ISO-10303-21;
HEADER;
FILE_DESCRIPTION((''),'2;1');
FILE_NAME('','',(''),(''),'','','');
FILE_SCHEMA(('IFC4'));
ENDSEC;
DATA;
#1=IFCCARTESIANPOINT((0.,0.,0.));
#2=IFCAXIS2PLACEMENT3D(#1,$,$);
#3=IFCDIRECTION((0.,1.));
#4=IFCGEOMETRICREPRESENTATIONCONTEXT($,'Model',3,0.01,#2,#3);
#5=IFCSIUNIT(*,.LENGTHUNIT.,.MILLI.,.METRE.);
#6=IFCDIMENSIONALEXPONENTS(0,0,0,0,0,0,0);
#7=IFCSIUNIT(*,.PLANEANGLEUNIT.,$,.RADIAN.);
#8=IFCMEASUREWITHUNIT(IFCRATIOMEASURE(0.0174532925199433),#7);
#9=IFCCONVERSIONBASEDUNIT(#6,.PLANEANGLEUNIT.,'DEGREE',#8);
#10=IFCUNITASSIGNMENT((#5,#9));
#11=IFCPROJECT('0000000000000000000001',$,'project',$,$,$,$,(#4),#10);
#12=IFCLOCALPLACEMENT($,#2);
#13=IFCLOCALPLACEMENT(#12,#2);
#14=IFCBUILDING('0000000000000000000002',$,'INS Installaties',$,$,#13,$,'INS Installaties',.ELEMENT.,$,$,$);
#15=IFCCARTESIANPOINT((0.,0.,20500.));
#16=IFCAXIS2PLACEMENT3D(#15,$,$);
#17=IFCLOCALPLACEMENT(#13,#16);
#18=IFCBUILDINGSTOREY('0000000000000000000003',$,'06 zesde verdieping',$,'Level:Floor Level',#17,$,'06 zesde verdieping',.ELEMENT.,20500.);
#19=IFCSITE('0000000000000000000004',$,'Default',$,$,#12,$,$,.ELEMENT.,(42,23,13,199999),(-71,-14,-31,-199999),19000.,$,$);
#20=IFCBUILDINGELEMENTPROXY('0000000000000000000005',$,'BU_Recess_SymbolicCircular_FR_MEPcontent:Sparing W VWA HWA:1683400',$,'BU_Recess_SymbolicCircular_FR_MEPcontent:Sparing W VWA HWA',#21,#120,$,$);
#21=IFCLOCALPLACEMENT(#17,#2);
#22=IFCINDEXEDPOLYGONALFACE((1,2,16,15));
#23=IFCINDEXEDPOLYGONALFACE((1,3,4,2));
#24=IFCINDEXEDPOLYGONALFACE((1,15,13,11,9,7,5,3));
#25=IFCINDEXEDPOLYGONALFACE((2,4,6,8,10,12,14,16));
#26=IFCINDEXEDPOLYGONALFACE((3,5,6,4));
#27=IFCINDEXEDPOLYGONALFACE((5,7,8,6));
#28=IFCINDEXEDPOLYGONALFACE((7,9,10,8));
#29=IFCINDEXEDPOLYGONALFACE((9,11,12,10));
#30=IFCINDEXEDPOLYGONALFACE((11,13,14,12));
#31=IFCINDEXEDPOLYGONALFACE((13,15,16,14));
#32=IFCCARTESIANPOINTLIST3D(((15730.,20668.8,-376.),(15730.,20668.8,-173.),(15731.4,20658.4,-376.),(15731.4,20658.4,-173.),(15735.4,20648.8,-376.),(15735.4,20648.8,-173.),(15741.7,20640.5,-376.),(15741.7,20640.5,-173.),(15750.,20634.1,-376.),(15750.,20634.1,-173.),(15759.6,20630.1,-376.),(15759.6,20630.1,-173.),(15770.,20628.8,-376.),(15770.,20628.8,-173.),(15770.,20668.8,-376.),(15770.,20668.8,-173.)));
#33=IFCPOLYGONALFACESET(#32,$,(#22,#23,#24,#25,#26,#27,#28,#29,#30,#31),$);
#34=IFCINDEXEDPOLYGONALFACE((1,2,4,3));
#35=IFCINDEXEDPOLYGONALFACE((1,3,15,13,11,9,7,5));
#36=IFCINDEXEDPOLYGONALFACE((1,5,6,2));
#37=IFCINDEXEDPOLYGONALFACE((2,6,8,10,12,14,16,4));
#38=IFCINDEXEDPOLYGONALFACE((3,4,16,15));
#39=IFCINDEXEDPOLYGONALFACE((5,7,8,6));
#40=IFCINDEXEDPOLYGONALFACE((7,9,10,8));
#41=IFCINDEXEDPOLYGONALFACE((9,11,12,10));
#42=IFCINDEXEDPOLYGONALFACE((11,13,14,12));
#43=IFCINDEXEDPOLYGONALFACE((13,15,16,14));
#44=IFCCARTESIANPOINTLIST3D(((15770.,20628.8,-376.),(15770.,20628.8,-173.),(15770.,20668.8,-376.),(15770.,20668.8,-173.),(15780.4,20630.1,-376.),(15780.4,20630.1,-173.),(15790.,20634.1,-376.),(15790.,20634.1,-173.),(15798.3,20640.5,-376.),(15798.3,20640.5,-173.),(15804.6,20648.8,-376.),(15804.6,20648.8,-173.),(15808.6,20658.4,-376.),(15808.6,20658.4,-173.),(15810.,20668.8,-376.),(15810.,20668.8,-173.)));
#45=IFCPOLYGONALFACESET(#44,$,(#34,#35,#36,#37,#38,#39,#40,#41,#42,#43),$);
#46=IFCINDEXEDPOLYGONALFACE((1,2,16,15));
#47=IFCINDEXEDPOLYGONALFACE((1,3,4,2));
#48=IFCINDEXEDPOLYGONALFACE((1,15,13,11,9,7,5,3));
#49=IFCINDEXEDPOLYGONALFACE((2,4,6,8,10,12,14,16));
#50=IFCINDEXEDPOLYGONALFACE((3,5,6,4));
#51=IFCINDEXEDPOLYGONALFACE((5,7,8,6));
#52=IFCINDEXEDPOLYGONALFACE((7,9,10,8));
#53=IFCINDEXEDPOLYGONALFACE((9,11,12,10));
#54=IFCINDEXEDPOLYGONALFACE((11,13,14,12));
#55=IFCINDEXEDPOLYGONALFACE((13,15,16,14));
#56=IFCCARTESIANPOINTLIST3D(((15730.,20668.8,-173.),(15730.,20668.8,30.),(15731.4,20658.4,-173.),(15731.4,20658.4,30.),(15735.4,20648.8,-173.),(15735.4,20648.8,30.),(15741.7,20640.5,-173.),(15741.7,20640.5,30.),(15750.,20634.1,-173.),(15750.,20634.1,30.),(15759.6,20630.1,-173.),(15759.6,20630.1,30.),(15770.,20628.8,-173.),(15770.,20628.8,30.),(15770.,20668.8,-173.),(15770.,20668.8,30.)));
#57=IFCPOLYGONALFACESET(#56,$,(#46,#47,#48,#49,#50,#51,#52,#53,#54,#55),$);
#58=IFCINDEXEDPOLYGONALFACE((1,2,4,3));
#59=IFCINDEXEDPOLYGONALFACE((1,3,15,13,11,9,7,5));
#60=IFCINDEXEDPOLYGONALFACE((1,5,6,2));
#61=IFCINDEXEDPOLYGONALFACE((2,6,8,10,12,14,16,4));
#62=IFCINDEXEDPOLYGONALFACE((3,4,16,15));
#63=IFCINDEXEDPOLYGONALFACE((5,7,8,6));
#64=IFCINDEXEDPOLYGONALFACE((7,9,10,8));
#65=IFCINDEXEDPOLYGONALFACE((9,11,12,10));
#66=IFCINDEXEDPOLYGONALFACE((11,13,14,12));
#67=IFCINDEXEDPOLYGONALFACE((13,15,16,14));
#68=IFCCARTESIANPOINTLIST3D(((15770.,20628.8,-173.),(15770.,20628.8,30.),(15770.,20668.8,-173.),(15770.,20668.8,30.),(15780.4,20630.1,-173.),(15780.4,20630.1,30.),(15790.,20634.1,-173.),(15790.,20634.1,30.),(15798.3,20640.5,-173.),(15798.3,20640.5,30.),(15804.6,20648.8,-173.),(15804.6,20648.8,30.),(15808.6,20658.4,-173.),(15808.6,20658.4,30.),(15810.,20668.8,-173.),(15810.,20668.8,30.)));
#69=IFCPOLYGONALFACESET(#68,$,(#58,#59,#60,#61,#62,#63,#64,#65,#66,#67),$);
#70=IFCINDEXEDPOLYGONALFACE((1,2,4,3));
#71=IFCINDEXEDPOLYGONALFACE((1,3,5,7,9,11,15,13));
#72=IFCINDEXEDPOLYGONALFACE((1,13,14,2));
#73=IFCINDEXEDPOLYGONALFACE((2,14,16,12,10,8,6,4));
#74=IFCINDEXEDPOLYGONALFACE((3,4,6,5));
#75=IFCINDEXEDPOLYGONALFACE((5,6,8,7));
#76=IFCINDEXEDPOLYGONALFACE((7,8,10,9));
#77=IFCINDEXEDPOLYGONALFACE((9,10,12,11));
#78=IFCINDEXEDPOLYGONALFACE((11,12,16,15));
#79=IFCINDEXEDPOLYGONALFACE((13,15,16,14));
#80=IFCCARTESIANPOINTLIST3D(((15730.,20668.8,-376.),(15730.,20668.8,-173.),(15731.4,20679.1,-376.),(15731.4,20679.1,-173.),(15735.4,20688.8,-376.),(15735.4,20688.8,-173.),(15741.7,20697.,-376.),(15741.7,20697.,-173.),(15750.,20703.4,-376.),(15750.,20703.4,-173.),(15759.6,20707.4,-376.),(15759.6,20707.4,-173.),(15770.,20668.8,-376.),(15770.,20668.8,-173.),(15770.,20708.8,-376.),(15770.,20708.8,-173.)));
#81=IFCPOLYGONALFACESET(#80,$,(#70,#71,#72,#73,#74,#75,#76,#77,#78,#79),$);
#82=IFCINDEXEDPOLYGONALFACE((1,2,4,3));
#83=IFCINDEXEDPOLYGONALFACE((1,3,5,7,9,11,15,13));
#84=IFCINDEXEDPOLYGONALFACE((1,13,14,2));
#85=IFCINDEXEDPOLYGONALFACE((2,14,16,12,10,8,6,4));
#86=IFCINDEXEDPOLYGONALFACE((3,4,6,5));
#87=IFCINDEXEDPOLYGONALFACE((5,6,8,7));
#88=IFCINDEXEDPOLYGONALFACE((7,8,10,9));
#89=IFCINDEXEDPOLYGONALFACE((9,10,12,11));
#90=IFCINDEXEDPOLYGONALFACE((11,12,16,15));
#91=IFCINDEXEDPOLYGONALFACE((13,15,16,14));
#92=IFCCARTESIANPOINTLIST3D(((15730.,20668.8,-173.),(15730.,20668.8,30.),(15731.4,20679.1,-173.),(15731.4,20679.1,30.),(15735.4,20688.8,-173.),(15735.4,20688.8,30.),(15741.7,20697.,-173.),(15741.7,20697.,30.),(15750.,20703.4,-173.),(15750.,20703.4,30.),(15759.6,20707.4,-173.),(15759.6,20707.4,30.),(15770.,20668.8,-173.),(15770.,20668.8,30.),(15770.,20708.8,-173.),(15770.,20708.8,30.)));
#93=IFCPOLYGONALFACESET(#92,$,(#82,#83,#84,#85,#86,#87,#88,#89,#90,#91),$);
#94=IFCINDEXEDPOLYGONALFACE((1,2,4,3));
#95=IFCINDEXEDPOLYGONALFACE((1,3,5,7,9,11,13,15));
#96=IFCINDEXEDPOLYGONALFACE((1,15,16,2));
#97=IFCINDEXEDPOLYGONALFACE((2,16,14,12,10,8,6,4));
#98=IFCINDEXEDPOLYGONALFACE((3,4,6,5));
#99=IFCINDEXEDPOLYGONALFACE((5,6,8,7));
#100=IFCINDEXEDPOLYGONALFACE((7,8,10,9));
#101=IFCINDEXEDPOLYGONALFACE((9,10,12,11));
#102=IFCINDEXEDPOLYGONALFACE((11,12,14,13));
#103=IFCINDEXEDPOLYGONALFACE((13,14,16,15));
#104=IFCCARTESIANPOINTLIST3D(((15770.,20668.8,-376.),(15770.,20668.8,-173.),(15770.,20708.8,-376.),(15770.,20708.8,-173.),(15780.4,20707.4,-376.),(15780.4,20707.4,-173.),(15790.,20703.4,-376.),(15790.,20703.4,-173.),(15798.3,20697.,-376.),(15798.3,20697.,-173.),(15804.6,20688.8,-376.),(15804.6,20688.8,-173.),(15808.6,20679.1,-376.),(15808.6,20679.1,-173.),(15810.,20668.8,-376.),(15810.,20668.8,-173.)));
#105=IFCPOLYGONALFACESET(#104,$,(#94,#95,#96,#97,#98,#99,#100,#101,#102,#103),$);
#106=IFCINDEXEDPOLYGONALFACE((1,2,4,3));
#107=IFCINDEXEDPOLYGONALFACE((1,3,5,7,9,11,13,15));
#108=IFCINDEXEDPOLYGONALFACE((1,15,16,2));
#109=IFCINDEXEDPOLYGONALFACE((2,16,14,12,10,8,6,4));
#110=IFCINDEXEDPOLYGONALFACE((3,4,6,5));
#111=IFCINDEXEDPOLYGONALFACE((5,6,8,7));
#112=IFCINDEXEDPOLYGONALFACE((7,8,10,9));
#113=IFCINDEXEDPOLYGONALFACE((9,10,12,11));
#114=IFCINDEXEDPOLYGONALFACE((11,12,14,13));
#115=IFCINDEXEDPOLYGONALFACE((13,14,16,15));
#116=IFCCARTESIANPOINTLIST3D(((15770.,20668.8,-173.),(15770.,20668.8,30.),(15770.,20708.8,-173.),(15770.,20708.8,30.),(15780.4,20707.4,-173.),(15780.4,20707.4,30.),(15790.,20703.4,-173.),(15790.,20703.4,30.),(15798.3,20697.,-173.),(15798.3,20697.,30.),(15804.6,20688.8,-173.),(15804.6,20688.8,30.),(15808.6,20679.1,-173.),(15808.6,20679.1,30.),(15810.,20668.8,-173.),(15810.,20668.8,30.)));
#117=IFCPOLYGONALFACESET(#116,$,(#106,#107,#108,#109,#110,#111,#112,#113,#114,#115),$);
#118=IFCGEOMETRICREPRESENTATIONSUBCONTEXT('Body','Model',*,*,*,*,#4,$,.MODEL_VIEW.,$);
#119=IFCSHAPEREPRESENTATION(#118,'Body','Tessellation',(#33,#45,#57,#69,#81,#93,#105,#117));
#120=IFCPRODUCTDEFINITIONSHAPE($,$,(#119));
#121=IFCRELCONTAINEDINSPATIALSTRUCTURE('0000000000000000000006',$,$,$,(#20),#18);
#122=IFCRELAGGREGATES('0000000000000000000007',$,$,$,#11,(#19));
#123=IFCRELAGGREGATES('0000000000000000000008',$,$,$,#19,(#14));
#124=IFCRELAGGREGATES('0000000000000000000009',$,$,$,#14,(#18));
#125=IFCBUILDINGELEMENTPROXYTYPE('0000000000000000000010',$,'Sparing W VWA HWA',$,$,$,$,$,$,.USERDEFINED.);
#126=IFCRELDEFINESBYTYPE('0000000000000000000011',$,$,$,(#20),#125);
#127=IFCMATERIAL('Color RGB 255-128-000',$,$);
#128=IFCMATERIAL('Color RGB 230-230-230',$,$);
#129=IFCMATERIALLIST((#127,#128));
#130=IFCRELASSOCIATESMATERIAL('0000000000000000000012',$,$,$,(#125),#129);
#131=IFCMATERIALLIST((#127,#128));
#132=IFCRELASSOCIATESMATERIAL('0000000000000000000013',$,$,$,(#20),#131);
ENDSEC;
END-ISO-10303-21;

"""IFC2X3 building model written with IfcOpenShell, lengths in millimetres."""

from ifc_helpers import new_model, entity, si_unit, converted_unit, direction, frame, frame_2d, origin, place, context, subcontext, project, spatial, polyline, circle_curve, parameter, trimmed, segment, composite_curve, outline, extrude, source, transform, mapped, material, material_list, type_object, type_shapes, element, save


model = new_model("IFC2X3")

# Units and contexts
model_context = context("Model", 3, precision=0.01, world=origin(), true_north=direction((0.0, 1.0)))
body_context = subcontext(model_context, "Body", "Model", "MODEL_VIEW")
ifc_project = project(units=[si_unit("LENGTHUNIT", "METRE", prefix="MILLI"), converted_unit("PLANEANGLEUNIT", "DEGREE", entity("IfcRatioMeasure", 0.0174532925199433), si_unit("PLANEANGLEUNIT", "RADIAN"), dimensions=[0, 0, 0, 0, 0, 0, 0])], contexts=[model_context])

# Site, building, storey
site_placement = place(None, origin())
site = spatial("IfcSite", under=ifc_project, at=site_placement, Name="Default", CompositionType="ELEMENT", RefLatitude=(42, 23, 13, 199999), RefLongitude=(-71, -14, -31, -199999), RefElevation=19000.0)
building_placement = place(site_placement, origin())
building = spatial("IfcBuilding", under=site, at=building_placement, Name="INS Installaties", LongName="INS Installaties", CompositionType="ELEMENT")
storey_placement = place(building_placement, frame((0.0, 0.0, 20500.0)))
storey = spatial("IfcBuildingStorey", under=building, at=storey_placement, Name="06 zesde verdieping", ObjectType="Level:Floor Level", LongName="06 zesde verdieping", CompositionType="ELEMENT", Elevation=20500.0)

# Building element proxy
ifc_material_1 = material(Name="Color RGB 255-128-000")
ifc_material_2 = material(Name="Color RGB 230-230-230")
ifc_material_list_1 = material_list([ifc_material_1, ifc_material_2])
building_element_proxy_type_1 = type_object("IfcBuildingElementProxyType", Name="Sparing W VWA HWA", PredefinedType="USERDEFINED", material=ifc_material_list_1)
shared_shape_1 = source(origin(), body_context, "Body", "SweptSolid", [
    extrude(outline(composite_curve([segment(trimmed(circle_curve(frame_2d((13.3, 13.3), x_axis=(1.0, 0.0)), 40.0), [parameter(180.0)], [parameter(270.0)], True, "PARAMETER"), True, "CONTINUOUS"), segment(polyline([(13.3, -26.7), (13.3, 13.3)]), True, "CONTINUOUS"), segment(polyline([(13.3, 13.3), (-26.7, 13.3)]), True, "CONTINUOUS")], self_intersect=False)), frame((13.3, 13.3, -403.0), z_axis=(0.0, 0.0, 1.0), x_axis=(-1.0, 0.0, 0.0)), (0.0, 0.0, 1.0), 203.0),
    extrude(outline(composite_curve([segment(polyline([(-26.7, -13.3), (13.3, -13.3)]), True, "CONTINUOUS"), segment(polyline([(13.3, -13.3), (13.3, 26.7)]), True, "CONTINUOUS"), segment(trimmed(circle_curve(frame_2d((13.3, -13.3), x_axis=(1.0, 0.0)), 40.0), [parameter(90.0)], [parameter(180.0)], True, "PARAMETER"), True, "CONTINUOUS")], self_intersect=False)), frame((-13.3, 13.3, -403.0)), (0.0, 0.0, 1.0), 203.0),
    extrude(outline(composite_curve([segment(trimmed(circle_curve(frame_2d((13.3, 13.3), x_axis=(1.0, 0.0)), 40.0), [parameter(180.0)], [parameter(270.0)], True, "PARAMETER"), True, "CONTINUOUS"), segment(polyline([(13.3, -26.7), (13.3, 13.3)]), True, "CONTINUOUS"), segment(polyline([(13.3, 13.3), (-26.7, 13.3)]), True, "CONTINUOUS")], self_intersect=False)), frame((13.3, 13.3, -200.0), z_axis=(0.0, 0.0, 1.0), x_axis=(-1.0, 0.0, 0.0)), (0.0, 0.0, 1.0), 203.0),
    extrude(outline(composite_curve([segment(polyline([(-26.7, -13.3), (13.3, -13.3)]), True, "CONTINUOUS"), segment(polyline([(13.3, -13.3), (13.3, 26.7)]), True, "CONTINUOUS"), segment(trimmed(circle_curve(frame_2d((13.3, -13.3), x_axis=(1.0, 0.0)), 40.0), [parameter(90.0)], [parameter(180.0)], True, "PARAMETER"), True, "CONTINUOUS")], self_intersect=False)), frame((-13.3, 13.3, -200.0)), (0.0, 0.0, 1.0), 203.0),
    extrude(outline(composite_curve([segment(polyline([(-26.7, -13.3), (13.3, -13.3)]), True, "CONTINUOUS"), segment(polyline([(13.3, -13.3), (13.3, 26.7)]), True, "CONTINUOUS"), segment(trimmed(circle_curve(frame_2d((13.3, -13.3), x_axis=(1.0, 0.0)), 40.0), [parameter(90.0)], [parameter(180.0)], True, "PARAMETER"), True, "CONTINUOUS")], self_intersect=False)), frame((13.3, -13.3, -403.0), z_axis=(0.0, 0.0, 1.0), x_axis=(-1.0, 0.0, 0.0)), (0.0, 0.0, 1.0), 203.0),
    extrude(outline(composite_curve([segment(polyline([(-26.7, -13.3), (13.3, -13.3)]), True, "CONTINUOUS"), segment(polyline([(13.3, -13.3), (13.3, 26.7)]), True, "CONTINUOUS"), segment(trimmed(circle_curve(frame_2d((13.3, -13.3), x_axis=(1.0, 0.0)), 40.0), [parameter(90.0)], [parameter(180.0)], True, "PARAMETER"), True, "CONTINUOUS")], self_intersect=False)), frame((13.3, -13.3, -200.0), z_axis=(0.0, 0.0, 1.0), x_axis=(-1.0, 0.0, 0.0)), (0.0, 0.0, 1.0), 203.0),
    extrude(outline(composite_curve([segment(trimmed(circle_curve(frame_2d((13.3, 13.3), x_axis=(1.0, 0.0)), 40.0), [parameter(180.0)], [parameter(270.0)], True, "PARAMETER"), True, "CONTINUOUS"), segment(polyline([(13.3, -26.7), (13.3, 13.3)]), True, "CONTINUOUS"), segment(polyline([(13.3, 13.3), (-26.7, 13.3)]), True, "CONTINUOUS")], self_intersect=False)), frame((-13.3, -13.3, -403.0)), (0.0, 0.0, 1.0), 203.0),
    extrude(outline(composite_curve([segment(trimmed(circle_curve(frame_2d((13.3, 13.3), x_axis=(1.0, 0.0)), 40.0), [parameter(180.0)], [parameter(270.0)], True, "PARAMETER"), True, "CONTINUOUS"), segment(polyline([(13.3, -26.7), (13.3, 13.3)]), True, "CONTINUOUS"), segment(polyline([(13.3, 13.3), (-26.7, 13.3)]), True, "CONTINUOUS")], self_intersect=False)), frame((-13.3, -13.3, -200.0)), (0.0, 0.0, 1.0), 203.0),
])
type_shapes(building_element_proxy_type_1, [shared_shape_1])
ifc_material_list_2 = material_list([ifc_material_1, ifc_material_2])
proxy_1_placement = place(storey_placement, frame((15770.0, 20668.8, 27.0), z_axis=(0.0, 0.0, 1.0), x_axis=(-1.0, 0.0, 0.0)))
element("IfcBuildingElementProxy", 1, at=proxy_1_placement, inside=storey, type_object=building_element_proxy_type_1, material=ifc_material_list_2, Name="BU_Recess_SymbolicCircular_FR_MEPcontent:Sparing W VWA HWA:1683400", ObjectType="BU_Recess_SymbolicCircular_FR_MEPcontent:Sparing W VWA HWA", context=body_context, shape_type="MappedRepresentation", body=[
    mapped(shared_shape_1, transform((0.0, 0.0, 0.0), scale=1.0)),
])

save(model, "model.ifc")
